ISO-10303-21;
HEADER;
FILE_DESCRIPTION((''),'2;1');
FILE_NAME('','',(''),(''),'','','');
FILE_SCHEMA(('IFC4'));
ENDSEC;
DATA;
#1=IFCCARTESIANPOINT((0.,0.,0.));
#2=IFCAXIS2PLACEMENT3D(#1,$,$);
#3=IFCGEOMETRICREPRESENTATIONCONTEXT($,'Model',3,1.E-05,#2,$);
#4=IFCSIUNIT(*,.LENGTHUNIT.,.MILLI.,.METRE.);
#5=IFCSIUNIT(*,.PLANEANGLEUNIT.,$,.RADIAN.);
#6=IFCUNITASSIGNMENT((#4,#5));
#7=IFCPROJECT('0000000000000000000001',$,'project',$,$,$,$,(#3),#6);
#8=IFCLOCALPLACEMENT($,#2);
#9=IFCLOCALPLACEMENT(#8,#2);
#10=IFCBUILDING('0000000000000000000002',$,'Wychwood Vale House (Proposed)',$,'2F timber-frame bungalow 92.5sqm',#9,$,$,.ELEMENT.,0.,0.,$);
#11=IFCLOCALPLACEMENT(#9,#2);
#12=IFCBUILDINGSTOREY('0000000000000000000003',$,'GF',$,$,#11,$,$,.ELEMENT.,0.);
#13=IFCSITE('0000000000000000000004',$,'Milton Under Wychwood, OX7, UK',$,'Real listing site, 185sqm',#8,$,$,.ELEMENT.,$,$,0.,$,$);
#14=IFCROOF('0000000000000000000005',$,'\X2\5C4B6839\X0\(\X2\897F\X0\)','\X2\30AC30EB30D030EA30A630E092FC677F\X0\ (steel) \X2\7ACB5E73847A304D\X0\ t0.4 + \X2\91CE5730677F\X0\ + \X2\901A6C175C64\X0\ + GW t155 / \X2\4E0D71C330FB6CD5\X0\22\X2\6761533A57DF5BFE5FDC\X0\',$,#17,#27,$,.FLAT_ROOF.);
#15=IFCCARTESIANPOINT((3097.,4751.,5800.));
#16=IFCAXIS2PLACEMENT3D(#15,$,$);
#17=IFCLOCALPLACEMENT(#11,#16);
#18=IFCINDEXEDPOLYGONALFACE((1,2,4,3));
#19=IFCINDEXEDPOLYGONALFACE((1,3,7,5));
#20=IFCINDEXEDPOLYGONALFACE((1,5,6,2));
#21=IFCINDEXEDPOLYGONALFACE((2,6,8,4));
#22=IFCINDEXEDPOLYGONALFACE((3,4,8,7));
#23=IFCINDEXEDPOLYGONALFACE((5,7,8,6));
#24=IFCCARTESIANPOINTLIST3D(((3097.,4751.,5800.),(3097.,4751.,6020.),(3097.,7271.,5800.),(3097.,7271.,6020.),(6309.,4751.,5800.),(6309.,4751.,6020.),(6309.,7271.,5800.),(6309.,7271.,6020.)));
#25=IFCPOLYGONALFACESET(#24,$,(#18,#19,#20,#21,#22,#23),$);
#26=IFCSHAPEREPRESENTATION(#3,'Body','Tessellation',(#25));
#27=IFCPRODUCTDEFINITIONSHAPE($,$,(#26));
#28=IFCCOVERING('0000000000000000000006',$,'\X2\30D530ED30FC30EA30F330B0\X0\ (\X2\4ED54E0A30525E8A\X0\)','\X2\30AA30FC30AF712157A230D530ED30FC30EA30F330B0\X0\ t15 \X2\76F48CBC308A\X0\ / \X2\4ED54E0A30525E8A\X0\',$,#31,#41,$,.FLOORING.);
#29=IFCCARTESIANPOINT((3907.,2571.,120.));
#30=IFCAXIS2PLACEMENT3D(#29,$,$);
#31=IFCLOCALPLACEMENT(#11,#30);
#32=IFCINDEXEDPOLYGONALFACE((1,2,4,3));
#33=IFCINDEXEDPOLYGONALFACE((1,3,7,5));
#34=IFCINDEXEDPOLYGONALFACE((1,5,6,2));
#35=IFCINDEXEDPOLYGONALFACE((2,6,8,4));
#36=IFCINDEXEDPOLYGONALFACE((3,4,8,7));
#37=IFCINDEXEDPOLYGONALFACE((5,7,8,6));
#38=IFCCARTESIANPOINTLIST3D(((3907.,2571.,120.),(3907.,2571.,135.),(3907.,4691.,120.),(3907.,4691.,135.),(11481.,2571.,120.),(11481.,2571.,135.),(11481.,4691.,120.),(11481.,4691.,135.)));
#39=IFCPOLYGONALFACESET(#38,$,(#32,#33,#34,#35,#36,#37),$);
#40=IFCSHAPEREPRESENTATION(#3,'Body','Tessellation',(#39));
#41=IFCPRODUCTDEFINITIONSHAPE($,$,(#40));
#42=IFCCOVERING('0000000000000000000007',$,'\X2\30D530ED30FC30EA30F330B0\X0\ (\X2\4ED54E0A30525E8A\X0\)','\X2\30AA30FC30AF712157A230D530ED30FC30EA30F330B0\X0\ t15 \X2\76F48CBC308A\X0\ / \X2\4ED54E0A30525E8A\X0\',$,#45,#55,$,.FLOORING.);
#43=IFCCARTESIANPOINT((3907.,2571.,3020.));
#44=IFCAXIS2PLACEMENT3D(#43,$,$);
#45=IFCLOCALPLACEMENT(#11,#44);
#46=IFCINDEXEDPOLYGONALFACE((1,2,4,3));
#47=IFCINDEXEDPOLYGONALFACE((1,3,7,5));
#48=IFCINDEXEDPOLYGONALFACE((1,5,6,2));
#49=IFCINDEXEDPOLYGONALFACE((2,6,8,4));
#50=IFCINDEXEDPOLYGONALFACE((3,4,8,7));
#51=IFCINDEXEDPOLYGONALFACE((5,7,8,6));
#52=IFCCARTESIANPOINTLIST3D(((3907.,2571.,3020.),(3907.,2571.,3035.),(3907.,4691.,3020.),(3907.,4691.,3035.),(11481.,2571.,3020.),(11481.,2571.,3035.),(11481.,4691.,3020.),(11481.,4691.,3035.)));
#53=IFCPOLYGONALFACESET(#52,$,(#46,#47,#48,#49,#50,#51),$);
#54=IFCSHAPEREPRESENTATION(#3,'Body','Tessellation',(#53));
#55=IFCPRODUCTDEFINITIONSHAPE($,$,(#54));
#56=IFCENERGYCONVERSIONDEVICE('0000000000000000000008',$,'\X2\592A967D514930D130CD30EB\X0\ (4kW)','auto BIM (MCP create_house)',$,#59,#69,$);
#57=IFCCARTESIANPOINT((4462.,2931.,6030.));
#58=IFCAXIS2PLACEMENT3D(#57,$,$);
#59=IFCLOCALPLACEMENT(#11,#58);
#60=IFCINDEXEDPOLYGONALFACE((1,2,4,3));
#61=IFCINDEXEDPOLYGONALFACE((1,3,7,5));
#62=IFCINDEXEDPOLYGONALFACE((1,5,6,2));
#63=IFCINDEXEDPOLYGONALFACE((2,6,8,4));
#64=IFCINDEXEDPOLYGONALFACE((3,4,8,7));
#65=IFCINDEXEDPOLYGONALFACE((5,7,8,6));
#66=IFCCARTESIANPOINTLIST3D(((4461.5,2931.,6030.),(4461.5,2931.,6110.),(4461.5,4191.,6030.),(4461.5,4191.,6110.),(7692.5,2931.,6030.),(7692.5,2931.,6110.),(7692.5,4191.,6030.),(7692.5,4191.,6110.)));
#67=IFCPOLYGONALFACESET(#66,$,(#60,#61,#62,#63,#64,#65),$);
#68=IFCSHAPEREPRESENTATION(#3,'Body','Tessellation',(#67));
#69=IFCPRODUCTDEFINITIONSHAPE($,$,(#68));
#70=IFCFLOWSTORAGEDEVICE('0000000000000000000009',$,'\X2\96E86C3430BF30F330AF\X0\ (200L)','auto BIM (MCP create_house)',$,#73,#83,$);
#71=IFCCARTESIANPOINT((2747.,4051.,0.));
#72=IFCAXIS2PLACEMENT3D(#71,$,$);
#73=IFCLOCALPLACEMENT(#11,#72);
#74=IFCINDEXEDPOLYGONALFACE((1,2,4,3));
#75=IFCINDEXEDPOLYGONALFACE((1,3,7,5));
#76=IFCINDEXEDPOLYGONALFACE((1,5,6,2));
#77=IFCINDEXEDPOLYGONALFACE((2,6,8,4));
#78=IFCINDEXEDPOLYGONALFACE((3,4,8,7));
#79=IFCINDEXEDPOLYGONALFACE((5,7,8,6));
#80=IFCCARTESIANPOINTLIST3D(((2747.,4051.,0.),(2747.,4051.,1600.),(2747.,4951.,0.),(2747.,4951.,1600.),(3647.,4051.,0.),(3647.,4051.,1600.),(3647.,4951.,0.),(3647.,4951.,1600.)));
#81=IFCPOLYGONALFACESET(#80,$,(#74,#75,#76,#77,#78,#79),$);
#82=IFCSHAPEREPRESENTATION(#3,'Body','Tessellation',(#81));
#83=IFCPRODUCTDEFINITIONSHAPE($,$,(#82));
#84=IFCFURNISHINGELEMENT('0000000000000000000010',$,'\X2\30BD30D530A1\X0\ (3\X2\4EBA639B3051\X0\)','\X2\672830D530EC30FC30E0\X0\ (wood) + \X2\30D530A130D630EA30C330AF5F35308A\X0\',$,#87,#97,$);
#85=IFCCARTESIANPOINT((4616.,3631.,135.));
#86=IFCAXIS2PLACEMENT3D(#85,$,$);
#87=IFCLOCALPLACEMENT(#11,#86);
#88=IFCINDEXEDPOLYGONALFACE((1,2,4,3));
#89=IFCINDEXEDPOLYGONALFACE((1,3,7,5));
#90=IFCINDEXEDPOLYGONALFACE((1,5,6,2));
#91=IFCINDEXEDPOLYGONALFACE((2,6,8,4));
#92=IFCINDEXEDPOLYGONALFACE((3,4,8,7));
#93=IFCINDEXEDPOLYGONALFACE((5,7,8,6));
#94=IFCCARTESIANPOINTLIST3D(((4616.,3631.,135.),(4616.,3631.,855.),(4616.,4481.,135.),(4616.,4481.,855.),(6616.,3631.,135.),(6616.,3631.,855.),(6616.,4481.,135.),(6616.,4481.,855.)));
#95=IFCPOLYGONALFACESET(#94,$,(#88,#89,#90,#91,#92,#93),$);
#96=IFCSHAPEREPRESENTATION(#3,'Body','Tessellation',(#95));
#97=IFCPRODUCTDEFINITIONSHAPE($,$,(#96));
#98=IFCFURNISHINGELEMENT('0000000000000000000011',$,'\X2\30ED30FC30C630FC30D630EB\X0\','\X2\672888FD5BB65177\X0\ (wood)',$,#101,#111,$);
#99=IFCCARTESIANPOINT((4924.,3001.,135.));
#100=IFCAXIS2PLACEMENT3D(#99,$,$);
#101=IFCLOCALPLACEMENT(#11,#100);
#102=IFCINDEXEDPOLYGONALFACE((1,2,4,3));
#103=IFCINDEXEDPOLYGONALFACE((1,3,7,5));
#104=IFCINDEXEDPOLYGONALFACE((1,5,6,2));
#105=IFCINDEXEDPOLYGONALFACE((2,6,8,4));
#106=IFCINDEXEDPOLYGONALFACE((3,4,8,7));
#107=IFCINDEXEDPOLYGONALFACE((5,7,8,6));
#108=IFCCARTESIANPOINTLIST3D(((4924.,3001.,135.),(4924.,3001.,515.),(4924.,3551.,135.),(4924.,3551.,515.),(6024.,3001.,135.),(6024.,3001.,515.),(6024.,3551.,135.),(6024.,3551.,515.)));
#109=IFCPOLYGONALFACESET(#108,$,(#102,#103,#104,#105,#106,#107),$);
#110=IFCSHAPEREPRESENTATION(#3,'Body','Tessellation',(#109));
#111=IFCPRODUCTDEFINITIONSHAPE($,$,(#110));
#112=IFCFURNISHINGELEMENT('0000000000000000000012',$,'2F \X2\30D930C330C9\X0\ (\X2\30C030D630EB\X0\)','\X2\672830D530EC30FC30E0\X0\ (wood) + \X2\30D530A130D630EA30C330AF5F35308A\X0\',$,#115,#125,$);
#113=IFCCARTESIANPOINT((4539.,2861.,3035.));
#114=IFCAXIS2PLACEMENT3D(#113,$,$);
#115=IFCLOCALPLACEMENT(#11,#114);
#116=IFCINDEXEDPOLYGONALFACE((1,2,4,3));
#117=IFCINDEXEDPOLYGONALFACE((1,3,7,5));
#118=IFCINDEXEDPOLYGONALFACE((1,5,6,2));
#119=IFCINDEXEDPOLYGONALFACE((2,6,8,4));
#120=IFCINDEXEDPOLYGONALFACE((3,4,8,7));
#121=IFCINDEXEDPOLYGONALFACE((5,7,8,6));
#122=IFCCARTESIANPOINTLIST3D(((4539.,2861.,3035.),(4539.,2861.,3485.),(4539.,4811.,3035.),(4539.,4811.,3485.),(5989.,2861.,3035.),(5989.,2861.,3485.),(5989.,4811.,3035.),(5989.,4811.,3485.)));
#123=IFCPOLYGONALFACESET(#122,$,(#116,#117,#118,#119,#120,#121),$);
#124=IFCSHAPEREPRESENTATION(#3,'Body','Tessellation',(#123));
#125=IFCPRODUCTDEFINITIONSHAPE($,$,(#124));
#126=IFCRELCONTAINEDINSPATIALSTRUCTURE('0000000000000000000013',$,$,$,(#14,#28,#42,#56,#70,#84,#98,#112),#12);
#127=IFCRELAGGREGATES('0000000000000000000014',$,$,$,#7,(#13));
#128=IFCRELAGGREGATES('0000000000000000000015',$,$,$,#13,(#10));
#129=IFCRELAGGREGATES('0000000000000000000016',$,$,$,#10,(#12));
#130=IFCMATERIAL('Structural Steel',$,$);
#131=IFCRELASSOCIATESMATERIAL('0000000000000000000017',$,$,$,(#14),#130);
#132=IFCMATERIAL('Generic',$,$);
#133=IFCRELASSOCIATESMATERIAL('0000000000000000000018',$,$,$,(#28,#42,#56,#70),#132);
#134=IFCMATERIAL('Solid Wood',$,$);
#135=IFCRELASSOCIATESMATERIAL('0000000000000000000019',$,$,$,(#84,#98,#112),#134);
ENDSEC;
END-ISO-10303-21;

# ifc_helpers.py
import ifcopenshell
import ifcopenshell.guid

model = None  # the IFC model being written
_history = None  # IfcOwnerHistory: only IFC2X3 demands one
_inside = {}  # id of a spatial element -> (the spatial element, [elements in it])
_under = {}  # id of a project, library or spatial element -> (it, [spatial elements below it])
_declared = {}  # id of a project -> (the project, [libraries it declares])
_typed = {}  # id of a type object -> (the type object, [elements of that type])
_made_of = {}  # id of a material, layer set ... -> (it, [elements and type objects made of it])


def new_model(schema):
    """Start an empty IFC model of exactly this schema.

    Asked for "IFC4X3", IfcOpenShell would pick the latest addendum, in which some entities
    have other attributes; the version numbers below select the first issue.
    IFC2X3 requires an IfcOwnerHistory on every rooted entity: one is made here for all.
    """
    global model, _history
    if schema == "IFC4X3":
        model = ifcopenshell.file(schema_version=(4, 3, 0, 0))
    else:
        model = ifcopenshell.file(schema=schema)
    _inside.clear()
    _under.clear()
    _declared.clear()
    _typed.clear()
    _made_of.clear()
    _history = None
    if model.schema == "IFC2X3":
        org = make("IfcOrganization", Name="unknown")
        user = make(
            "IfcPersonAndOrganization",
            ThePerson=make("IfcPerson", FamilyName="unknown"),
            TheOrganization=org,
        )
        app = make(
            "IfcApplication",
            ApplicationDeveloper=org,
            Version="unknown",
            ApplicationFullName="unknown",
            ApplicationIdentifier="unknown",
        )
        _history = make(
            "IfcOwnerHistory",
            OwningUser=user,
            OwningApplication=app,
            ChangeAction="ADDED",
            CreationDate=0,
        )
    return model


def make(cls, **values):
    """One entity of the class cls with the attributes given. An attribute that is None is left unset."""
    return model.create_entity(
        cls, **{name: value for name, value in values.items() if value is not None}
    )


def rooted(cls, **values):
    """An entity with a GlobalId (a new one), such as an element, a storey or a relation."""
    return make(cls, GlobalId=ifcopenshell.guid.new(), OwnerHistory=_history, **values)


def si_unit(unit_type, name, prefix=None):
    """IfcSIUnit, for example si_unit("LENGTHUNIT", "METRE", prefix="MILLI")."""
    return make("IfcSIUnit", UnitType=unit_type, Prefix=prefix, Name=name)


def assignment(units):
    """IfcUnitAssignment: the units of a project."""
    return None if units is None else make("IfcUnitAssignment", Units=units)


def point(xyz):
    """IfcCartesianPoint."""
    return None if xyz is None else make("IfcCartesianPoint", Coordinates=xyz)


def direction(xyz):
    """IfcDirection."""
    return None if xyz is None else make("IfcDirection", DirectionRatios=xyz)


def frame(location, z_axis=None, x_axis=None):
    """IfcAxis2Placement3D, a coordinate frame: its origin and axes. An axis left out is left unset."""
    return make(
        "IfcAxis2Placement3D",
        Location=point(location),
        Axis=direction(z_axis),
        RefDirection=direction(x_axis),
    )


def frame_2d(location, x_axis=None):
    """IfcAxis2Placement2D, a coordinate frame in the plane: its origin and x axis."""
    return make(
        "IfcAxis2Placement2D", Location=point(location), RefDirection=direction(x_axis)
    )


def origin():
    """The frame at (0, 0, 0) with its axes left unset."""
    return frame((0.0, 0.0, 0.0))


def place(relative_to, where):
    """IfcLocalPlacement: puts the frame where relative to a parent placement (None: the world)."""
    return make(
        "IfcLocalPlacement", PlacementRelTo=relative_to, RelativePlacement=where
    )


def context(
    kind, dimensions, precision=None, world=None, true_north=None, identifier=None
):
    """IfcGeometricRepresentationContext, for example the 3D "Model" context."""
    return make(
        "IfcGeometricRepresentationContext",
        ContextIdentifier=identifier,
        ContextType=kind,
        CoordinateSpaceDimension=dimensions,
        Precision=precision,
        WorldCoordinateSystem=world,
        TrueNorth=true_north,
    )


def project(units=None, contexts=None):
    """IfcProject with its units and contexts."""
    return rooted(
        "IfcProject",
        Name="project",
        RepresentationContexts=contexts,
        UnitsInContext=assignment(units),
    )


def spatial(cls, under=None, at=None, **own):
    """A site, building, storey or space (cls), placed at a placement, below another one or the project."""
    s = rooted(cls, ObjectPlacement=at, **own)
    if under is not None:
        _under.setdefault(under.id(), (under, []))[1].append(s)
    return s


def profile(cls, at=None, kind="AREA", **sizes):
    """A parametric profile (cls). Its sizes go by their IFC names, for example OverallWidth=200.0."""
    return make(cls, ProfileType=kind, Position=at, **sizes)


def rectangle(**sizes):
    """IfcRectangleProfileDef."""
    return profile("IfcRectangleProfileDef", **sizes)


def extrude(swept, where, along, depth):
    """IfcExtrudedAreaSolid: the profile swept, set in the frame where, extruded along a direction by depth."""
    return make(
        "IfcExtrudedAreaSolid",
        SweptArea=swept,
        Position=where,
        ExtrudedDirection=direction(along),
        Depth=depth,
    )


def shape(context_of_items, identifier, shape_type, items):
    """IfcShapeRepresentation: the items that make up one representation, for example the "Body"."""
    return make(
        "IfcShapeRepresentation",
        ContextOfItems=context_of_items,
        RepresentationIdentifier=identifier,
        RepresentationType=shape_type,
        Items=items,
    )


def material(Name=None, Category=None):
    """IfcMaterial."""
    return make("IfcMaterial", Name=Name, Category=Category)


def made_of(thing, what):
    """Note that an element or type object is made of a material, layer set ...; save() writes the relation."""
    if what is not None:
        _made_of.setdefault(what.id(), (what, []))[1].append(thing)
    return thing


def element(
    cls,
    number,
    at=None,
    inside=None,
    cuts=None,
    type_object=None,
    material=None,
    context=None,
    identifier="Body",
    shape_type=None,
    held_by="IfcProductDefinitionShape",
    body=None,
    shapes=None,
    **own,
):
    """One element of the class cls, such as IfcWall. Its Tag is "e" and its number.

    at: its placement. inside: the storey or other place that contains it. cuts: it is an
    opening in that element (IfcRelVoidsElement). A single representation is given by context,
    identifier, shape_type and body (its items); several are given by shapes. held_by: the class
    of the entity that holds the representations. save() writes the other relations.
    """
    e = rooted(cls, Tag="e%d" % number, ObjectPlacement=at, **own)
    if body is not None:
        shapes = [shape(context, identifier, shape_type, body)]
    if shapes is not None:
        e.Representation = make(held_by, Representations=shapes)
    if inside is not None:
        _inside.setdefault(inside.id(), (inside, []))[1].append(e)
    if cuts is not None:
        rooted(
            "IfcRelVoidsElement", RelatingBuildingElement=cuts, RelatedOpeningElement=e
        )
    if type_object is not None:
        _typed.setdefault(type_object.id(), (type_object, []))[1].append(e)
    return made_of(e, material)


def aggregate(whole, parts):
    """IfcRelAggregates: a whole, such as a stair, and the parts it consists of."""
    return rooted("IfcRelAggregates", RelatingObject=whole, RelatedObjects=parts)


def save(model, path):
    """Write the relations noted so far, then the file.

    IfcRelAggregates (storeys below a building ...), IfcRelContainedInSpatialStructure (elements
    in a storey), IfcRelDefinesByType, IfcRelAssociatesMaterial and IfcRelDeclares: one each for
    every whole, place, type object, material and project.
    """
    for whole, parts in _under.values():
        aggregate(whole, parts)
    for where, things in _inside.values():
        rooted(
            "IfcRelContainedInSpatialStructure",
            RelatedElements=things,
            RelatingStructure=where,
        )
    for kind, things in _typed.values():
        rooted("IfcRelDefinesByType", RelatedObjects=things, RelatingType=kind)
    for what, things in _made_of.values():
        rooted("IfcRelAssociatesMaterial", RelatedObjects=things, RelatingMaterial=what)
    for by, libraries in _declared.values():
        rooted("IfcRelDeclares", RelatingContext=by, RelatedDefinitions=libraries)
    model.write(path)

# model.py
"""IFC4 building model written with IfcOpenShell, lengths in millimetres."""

from ifc_helpers import new_model, si_unit, frame, frame_2d, origin, place, context, project, spatial, rectangle, extrude, material, element, save


model = new_model("IFC4")

# Units and contexts
model_context = context("Model", 3, precision=1e-05, world=origin())
ifc_project = project(units=[si_unit("LENGTHUNIT", "METRE", prefix="MILLI"), si_unit("PLANEANGLEUNIT", "RADIAN")], contexts=[model_context])

# Site, building, storey
site_placement = place(None, origin())
site = spatial("IfcSite", under=ifc_project, at=site_placement, Name="Milton Under Wychwood, OX7, UK", ObjectType="Real listing site, 185sqm", CompositionType="ELEMENT", RefElevation=0.0)
building_placement = place(site_placement, origin())
building = spatial("IfcBuilding", under=site, at=building_placement, Name="Wychwood Vale House (Proposed)", ObjectType="2F timber-frame bungalow 92.5sqm", CompositionType="ELEMENT", ElevationOfRefHeight=0.0, ElevationOfTerrain=0.0)
storey_placement = place(building_placement, origin())
storey = spatial("IfcBuildingStorey", under=building, at=storey_placement, Name="GF", CompositionType="ELEMENT", Elevation=0.0)

# Shared definitions
ifc_material_1 = material(Name="Solid Wood")

# Roof
ifc_material_2 = material(Name="Structural Steel")
roof_1_placement = place(storey_placement, frame((3097.0, 4751.0, 5800.0)))
element("IfcRoof", 1, at=roof_1_placement, inside=storey, material=ifc_material_2, Name="屋根(西)", Description="ガルバリウム鋼板 (steel) 立平葺き t0.4 + 野地板 + 通気層 + GW t155 / 不燃・法22条区域対応", PredefinedType="FLAT_ROOF", context=model_context, shape_type="SweptSolid", body=[
    extrude(rectangle(XDim=3212.0, YDim=2520.0, at=frame_2d((1606.0, 1260.0))), frame((3097.0, 4751.0, 5800.0)), (0.0, 0.0, 1.0), 220.0),
])

# Coverings
ifc_material_3 = material(Name="Generic")
covering_1_placement = place(storey_placement, frame((3907.0, 2571.0, 120.0)))
element("IfcCovering", 2, at=covering_1_placement, inside=storey, material=ifc_material_3, Name="フローリング (仕上げ床)", Description="オーク無垢フローリング t15 直貼り / 仕上げ床", PredefinedType="FLOORING", context=model_context, shape_type="SweptSolid", body=[
    extrude(rectangle(XDim=7574.0, YDim=2120.0, at=frame_2d((3787.0, 1060.0))), frame((3907.0, 2571.0, 120.0)), (0.0, 0.0, 1.0), 15.0),
])
covering_2_placement = place(storey_placement, frame((3907.0, 2571.0, 3020.0)))
element("IfcCovering", 3, at=covering_2_placement, inside=storey, material=ifc_material_3, Name="フローリング (仕上げ床)", Description="オーク無垢フローリング t15 直貼り / 仕上げ床", PredefinedType="FLOORING", context=model_context, shape_type="SweptSolid", body=[
    extrude(rectangle(XDim=7574.0, YDim=2120.0, at=frame_2d((3787.0, 1060.0))), frame((3907.0, 2571.0, 3020.0)), (0.0, 0.0, 1.0), 15.0),
])

# Energy conversion device
energy_conversion_device_placement = place(storey_placement, frame((4462.0, 2931.0, 6030.0)))
element("IfcEnergyConversionDevice", 4, at=energy_conversion_device_placement, inside=storey, material=ifc_material_3, Name="太陽光パネル (4kW)", Description="auto BIM (MCP create_house)", context=model_context, shape_type="SweptSolid", body=[
    extrude(rectangle(XDim=3231.0, YDim=1260.0, at=frame_2d((1615.0, 630.0))), frame((4462.0, 2931.0, 6030.0)), (0.0, 0.0, 1.0), 80.0),
])

# Flow storage device
flow_storage_device_placement = place(storey_placement, frame((2747.0, 4051.0, 0.0)))
element("IfcFlowStorageDevice", 5, at=flow_storage_device_placement, inside=storey, material=ifc_material_3, Name="雨水タンク (200L)", Description="auto BIM (MCP create_house)", context=model_context, shape_type="SweptSolid", body=[
    extrude(rectangle(XDim=900.0, YDim=900.0, at=frame_2d((450.0, 450.0))), frame((2747.0, 4051.0, 0.0)), (0.0, 0.0, 1.0), 1600.0),
])

# Furnishing elements
furnishing_1_placement = place(storey_placement, frame((4616.0, 3631.0, 135.0)))
element("IfcFurnishingElement", 6, at=furnishing_1_placement, inside=storey, material=ifc_material_1, Name="ソファ (3人掛け)", Description="木フレーム (wood) + ファブリック張り", context=model_context, shape_type="SweptSolid", body=[
    extrude(rectangle(XDim=2000.0, YDim=850.0, at=frame_2d((1000.0, 425.0))), frame((4616.0, 3631.0, 135.0)), (0.0, 0.0, 1.0), 720.0),
])
furnishing_2_placement = place(storey_placement, frame((4924.0, 3001.0, 135.0)))
element("IfcFurnishingElement", 7, at=furnishing_2_placement, inside=storey, material=ifc_material_1, Name="ローテーブル", Description="木製家具 (wood)", context=model_context, shape_type="SweptSolid", body=[
    extrude(rectangle(XDim=1100.0, YDim=550.0, at=frame_2d((550.0, 275.0))), frame((4924.0, 3001.0, 135.0)), (0.0, 0.0, 1.0), 380.0),
])
furnishing_3_placement = place(storey_placement, frame((4539.0, 2861.0, 3035.0)))
element("IfcFurnishingElement", 8, at=furnishing_3_placement, inside=storey, material=ifc_material_1, Name="2F ベッド (ダブル)", Description="木フレーム (wood) + ファブリック張り", context=model_context, shape_type="SweptSolid", body=[
    extrude(rectangle(XDim=1450.0, YDim=1950.0, at=frame_2d((725.0, 975.0))), frame((4539.0, 2861.0, 3035.0)), (0.0, 0.0, 1.0), 450.0),
])

save(model, "model.ifc")
